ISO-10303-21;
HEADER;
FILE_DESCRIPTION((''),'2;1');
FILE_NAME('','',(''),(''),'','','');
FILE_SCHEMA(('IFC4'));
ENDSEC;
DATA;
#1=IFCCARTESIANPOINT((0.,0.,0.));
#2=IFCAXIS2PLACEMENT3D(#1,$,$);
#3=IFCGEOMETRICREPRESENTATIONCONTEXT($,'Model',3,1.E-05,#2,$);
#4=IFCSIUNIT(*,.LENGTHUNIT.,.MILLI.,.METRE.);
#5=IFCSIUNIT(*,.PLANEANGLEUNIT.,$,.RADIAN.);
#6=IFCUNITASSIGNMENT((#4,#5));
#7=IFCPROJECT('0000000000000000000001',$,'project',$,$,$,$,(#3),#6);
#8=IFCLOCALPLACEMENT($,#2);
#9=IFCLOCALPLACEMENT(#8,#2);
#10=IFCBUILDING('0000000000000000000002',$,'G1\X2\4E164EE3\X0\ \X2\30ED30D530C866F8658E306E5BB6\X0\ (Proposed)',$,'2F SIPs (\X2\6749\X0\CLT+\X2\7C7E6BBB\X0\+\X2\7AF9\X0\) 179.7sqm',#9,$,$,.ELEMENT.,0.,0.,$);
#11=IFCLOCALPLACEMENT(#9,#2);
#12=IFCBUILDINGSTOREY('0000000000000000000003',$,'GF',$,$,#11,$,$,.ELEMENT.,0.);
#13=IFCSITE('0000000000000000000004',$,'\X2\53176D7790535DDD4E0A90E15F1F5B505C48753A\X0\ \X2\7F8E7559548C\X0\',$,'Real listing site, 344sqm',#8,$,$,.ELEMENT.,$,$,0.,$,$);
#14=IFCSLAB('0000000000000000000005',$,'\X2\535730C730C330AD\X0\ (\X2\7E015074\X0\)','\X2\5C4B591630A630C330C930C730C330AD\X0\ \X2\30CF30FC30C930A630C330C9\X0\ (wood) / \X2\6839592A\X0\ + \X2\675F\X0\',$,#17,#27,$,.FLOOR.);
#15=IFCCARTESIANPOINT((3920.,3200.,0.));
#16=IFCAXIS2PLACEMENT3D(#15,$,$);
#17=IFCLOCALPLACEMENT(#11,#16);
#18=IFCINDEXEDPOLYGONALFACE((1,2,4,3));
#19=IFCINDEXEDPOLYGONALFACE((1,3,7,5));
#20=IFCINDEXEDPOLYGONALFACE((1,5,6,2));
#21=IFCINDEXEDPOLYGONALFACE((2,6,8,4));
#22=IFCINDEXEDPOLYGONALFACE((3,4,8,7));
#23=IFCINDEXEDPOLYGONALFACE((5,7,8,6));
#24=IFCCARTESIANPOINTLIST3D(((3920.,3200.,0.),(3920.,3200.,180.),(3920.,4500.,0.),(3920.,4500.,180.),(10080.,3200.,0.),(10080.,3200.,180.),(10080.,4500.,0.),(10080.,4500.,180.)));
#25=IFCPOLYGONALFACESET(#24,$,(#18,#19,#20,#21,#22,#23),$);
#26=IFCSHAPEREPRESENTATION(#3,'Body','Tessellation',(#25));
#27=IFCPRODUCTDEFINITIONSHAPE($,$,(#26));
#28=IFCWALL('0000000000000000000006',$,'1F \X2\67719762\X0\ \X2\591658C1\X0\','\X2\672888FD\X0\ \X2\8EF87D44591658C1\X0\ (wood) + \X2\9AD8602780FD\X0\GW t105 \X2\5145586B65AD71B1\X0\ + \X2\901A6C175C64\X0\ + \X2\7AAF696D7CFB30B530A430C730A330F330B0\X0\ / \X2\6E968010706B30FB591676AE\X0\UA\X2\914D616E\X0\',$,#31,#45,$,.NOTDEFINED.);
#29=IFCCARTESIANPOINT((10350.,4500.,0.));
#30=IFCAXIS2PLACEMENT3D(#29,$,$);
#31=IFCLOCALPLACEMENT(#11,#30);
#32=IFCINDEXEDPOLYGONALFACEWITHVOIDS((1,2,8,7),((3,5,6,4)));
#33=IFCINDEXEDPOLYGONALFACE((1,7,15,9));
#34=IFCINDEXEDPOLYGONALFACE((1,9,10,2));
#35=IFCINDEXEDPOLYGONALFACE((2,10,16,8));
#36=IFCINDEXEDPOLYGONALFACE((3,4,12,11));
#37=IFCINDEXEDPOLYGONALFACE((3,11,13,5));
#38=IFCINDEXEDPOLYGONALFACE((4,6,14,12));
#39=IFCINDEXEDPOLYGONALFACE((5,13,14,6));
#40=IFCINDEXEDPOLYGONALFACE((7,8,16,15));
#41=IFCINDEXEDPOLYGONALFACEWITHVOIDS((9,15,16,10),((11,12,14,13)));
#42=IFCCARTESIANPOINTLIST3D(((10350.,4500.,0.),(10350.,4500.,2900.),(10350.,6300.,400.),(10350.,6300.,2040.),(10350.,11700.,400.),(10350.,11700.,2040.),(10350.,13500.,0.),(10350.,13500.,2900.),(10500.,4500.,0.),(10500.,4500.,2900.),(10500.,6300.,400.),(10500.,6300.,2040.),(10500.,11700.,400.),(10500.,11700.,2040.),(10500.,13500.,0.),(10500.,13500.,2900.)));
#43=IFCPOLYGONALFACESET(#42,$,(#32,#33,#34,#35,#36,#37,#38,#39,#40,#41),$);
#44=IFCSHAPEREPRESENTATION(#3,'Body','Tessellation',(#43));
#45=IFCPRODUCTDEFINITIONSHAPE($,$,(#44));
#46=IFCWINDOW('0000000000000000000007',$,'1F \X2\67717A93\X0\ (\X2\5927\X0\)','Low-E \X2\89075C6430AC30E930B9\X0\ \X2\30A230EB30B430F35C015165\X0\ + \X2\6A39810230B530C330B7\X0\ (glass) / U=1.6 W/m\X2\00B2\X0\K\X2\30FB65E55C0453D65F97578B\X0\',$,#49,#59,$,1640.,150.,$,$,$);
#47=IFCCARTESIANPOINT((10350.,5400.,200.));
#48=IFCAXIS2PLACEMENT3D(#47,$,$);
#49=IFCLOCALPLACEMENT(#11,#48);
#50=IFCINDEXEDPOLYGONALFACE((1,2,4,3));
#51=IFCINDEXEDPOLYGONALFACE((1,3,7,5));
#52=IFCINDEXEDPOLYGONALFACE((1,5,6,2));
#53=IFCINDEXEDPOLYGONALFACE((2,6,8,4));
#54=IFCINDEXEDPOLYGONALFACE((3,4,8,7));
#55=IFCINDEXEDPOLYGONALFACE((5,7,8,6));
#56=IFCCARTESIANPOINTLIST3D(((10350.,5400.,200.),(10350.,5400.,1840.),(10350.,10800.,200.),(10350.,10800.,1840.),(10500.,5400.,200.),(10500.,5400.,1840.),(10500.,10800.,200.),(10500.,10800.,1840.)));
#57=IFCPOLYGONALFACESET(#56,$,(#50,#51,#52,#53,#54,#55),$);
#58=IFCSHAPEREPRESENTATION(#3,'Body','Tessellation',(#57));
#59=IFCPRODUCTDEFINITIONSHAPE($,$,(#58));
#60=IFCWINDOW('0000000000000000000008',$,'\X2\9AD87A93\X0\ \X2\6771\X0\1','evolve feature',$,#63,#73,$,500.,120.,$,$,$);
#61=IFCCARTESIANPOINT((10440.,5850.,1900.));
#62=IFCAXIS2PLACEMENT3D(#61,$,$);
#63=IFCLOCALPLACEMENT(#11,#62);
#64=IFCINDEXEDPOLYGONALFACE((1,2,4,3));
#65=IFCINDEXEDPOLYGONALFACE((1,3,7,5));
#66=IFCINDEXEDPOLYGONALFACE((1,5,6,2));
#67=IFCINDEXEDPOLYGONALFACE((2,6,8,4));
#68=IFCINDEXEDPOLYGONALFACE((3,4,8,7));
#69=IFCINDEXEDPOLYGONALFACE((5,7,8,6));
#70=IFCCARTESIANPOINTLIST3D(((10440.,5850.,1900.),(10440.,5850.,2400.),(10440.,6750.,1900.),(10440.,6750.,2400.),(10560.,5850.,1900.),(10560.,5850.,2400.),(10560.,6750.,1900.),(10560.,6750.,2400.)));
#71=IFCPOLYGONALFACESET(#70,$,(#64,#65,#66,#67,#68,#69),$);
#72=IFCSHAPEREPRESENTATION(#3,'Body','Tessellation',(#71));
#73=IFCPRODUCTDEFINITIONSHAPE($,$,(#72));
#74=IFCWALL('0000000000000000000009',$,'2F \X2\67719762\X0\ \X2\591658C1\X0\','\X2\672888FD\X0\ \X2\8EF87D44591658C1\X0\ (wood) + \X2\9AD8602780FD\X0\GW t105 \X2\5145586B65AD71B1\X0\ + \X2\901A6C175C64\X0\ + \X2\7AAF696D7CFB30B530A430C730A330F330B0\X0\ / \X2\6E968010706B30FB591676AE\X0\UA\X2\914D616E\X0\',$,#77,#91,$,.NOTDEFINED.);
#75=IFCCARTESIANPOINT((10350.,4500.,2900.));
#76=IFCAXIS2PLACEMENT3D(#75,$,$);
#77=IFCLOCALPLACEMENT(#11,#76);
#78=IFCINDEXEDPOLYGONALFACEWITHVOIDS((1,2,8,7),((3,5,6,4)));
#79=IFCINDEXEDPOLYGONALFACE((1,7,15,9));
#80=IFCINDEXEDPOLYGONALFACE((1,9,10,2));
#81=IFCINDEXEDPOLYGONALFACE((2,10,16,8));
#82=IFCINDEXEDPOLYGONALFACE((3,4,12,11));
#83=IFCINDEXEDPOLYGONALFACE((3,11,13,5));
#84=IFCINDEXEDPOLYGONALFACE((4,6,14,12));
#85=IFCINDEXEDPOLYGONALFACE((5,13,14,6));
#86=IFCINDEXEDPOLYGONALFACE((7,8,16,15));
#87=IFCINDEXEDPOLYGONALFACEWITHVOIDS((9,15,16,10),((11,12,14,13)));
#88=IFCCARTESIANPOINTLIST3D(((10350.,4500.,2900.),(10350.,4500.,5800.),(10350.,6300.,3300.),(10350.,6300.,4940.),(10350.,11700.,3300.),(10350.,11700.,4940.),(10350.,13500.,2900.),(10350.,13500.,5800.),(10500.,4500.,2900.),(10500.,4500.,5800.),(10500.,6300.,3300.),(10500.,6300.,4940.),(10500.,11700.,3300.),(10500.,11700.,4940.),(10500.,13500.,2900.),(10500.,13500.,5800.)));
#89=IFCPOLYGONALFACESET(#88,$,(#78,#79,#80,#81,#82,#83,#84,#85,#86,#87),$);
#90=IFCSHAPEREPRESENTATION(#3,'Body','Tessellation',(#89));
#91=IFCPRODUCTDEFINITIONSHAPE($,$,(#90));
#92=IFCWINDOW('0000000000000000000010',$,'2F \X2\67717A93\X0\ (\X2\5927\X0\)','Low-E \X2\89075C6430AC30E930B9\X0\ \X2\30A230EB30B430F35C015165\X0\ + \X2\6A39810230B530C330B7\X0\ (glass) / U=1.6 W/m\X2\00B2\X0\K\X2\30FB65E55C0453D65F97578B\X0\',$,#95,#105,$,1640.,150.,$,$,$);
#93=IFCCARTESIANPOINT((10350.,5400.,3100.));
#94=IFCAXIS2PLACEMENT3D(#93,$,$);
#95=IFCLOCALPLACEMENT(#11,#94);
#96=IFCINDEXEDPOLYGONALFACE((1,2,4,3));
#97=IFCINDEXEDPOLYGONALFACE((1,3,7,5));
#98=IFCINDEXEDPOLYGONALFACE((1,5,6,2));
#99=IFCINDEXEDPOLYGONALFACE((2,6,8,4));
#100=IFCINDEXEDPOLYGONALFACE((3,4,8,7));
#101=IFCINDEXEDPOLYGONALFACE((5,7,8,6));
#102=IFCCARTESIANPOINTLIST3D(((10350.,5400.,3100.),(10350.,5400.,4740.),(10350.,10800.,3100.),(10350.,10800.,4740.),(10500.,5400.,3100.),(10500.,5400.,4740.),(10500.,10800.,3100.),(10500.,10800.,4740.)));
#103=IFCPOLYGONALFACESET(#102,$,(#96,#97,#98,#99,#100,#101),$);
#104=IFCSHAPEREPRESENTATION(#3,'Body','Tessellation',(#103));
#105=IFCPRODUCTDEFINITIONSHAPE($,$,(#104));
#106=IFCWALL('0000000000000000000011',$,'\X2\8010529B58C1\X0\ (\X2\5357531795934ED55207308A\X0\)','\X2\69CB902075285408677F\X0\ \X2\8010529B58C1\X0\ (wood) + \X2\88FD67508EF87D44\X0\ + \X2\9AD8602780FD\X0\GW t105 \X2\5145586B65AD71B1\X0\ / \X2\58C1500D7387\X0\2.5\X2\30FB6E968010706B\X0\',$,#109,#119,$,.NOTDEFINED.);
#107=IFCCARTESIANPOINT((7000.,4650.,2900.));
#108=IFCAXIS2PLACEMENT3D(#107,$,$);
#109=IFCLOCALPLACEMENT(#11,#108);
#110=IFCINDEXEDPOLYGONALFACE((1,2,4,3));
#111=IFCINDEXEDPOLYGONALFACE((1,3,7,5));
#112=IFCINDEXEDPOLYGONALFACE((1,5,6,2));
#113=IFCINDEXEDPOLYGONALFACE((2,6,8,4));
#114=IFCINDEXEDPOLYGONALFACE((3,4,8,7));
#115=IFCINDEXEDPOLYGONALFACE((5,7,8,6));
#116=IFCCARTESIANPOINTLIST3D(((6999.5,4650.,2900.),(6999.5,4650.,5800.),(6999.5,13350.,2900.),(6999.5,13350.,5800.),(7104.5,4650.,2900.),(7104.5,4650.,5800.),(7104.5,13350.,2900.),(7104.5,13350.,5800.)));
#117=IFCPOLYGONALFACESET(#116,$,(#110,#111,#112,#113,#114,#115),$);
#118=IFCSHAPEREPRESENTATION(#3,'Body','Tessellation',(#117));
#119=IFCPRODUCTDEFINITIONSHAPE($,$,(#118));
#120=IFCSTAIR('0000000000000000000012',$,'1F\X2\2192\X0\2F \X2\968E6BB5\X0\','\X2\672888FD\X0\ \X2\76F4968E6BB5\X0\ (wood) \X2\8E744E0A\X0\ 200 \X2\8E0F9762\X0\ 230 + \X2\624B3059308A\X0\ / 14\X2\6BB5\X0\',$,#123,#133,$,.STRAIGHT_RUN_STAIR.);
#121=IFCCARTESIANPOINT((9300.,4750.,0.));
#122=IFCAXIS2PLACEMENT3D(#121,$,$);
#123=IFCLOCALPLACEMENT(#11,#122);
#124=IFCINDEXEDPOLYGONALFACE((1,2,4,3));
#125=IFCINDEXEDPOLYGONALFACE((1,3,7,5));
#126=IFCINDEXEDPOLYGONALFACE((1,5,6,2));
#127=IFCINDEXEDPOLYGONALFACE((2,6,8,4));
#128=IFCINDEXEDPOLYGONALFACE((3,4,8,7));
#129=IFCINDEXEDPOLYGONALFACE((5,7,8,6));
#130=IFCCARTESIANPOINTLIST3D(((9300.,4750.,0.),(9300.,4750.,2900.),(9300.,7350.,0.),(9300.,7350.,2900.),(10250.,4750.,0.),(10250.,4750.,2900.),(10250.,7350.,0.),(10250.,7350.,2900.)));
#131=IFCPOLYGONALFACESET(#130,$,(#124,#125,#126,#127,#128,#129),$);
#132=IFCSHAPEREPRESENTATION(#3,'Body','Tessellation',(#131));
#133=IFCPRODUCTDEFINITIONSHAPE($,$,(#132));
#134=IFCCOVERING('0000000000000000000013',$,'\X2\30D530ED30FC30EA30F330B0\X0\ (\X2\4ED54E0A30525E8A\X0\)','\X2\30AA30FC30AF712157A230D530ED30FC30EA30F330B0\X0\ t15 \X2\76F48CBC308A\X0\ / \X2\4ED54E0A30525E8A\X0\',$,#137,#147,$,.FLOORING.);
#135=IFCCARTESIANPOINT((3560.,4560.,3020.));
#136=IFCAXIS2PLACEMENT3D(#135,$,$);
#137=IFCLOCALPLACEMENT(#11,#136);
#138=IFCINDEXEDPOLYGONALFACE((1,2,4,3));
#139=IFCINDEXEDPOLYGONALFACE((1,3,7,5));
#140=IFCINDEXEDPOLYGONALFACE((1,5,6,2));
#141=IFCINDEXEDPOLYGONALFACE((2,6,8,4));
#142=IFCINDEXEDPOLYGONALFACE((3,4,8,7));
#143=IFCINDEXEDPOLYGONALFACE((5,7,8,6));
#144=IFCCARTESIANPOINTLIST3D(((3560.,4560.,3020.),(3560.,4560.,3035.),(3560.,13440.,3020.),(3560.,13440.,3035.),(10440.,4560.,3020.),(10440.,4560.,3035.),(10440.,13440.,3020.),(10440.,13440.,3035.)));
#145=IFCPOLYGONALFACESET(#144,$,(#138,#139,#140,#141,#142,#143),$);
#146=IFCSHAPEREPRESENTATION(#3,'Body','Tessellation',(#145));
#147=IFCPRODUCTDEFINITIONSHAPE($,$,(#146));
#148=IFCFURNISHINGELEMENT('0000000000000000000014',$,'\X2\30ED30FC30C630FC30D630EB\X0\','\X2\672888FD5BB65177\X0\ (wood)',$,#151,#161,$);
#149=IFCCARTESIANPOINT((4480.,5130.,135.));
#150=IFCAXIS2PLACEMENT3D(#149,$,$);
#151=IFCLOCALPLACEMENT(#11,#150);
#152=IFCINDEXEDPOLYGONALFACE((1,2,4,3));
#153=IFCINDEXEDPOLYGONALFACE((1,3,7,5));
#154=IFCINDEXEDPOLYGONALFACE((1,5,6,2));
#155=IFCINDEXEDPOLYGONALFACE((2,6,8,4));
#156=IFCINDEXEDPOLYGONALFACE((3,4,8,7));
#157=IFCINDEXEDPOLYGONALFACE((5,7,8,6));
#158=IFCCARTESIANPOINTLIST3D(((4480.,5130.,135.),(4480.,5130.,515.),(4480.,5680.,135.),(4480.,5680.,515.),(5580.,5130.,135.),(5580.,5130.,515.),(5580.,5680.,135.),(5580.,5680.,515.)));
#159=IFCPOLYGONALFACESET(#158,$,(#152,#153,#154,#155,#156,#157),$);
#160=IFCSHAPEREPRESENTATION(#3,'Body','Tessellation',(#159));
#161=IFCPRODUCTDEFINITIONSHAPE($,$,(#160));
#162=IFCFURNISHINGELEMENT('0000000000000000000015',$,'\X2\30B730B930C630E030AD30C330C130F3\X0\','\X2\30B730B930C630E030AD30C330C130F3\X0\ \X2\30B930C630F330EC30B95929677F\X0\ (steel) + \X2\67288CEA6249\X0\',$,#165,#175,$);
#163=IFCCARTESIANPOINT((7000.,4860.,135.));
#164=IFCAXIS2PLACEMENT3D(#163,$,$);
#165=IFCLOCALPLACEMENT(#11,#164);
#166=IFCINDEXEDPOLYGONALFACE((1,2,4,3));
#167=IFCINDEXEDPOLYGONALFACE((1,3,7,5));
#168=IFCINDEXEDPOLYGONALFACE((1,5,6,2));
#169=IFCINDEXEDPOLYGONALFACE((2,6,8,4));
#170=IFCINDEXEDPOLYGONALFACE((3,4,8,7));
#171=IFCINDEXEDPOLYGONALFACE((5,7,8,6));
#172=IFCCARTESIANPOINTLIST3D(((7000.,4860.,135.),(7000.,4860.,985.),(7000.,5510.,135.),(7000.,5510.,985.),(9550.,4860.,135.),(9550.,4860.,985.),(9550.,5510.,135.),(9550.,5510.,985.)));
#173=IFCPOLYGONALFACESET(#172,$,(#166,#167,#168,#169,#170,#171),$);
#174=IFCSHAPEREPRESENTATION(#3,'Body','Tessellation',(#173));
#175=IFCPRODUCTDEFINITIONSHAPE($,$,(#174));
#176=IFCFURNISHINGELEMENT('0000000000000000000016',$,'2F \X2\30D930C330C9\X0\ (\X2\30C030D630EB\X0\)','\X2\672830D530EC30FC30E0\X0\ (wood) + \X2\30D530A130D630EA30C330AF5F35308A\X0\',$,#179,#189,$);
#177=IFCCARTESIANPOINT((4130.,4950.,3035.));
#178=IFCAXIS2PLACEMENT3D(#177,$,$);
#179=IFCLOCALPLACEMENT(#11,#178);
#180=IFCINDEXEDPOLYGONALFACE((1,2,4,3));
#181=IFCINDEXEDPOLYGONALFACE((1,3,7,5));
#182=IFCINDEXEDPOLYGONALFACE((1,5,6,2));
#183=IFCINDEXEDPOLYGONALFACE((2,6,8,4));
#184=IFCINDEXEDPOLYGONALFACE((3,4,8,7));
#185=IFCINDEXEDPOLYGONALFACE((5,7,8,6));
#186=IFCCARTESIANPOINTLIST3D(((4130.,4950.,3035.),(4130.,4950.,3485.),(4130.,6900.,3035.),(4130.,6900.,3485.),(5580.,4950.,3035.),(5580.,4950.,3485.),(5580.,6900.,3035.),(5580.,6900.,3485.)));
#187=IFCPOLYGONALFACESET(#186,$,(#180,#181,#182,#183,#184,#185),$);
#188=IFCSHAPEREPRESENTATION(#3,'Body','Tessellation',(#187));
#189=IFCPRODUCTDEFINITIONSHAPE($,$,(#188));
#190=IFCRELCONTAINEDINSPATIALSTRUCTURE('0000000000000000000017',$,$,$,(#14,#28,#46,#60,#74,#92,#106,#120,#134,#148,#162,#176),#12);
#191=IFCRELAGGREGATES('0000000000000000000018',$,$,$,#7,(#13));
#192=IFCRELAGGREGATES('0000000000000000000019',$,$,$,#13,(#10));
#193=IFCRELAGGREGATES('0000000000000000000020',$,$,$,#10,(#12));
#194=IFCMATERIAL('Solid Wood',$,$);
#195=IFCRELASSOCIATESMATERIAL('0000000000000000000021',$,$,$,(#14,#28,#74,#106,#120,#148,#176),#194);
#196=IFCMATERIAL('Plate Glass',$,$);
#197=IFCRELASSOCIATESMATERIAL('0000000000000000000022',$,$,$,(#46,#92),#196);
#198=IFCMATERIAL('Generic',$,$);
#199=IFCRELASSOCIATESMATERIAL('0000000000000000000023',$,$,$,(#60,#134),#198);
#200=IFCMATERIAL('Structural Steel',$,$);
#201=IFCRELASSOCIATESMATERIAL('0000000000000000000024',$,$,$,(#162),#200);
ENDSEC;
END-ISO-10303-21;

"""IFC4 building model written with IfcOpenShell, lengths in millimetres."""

from ifc_helpers import new_model, si_unit, frame, frame_2d, origin, place, context, project, spatial, rectangle, extrude, material, element, fill, save


model = new_model("IFC4")

# Units and contexts
model_context = context("Model", 3, precision=1e-05, world=origin())
ifc_project = project(units=[si_unit("LENGTHUNIT", "METRE", prefix="MILLI"), si_unit("PLANEANGLEUNIT", "RADIAN")], contexts=[model_context])

# Site, building, storey
site_placement = place(None, origin())
site = spatial("IfcSite", under=ifc_project, at=site_placement, Name="北海道川上郡弟子屈町 美留和", ObjectType="Real listing site, 344sqm", CompositionType="ELEMENT", RefElevation=0.0)
building_placement = place(site_placement, origin())
building = spatial("IfcBuilding", under=site, at=building_placement, Name="G1世代 ロフト書斎の家 (Proposed)", ObjectType="2F SIPs (杉CLT+籾殻+竹) 179.7sqm", CompositionType="ELEMENT", ElevationOfRefHeight=0.0, ElevationOfTerrain=0.0)
storey_placement = place(building_placement, origin())
storey = spatial("IfcBuildingStorey", under=building, at=storey_placement, Name="GF", CompositionType="ELEMENT", Elevation=0.0)

# Slab
ifc_material_1 = material(Name="Solid Wood")
slab_placement = place(storey_placement, frame((3920.0, 3200.0, 0.0)))
element("IfcSlab", 1, at=slab_placement, inside=storey, material=ifc_material_1, Name="南デッキ (縁側)", Description="屋外ウッドデッキ ハードウッド (wood) / 根太 + 束", PredefinedType="FLOOR", context=model_context, shape_type="SweptSolid", body=[
    extrude(rectangle(XDim=6160.0, YDim=1300.0, at=frame_2d((3080.0, 650.0))), frame((3920.0, 3200.0, 0.0)), (0.0, 0.0, 1.0), 180.0),
])

# Wall, openings, windows
wall_1_placement = place(storey_placement, frame((10350.0, 4500.0, 0.0)))
wall_1 = element("IfcWall", 2, at=wall_1_placement, inside=storey, material=ifc_material_1, Name="1F 東面 外壁", Description="木製 軸組外壁 (wood) + 高性能GW t105 充填断熱 + 通気層 + 窯業系サイディング / 準耐火・外皮UA配慮", PredefinedType="NOTDEFINED", context=model_context, shape_type="SweptSolid", body=[
    extrude(rectangle(XDim=150.0, YDim=9000.0, at=frame_2d((75.0, 4500.0))), frame((10350.0, 4500.0, 0.0)), (0.0, 0.0, 1.0), 2900.0),
])
opening_1_placement = place(storey_placement, frame((10350.0, 5400.0, 200.0)))
opening_1 = element("IfcOpeningElement", 3, at=opening_1_placement, cuts=wall_1, PredefinedType="NOTDEFINED", context=model_context, shape_type="SweptSolid", body=[
    extrude(rectangle(XDim=150.0, YDim=5400.0, at=frame_2d((75.0, 2700.0))), frame((10350.0, 5400.0, 200.0)), (0.0, 0.0, 1.0), 1640.0),
])
opening_2_placement = place(storey_placement, frame((10440.0, 5850.0, 1900.0)))
opening_2 = element("IfcOpeningElement", 4, at=opening_2_placement, cuts=wall_1, PredefinedType="NOTDEFINED", context=model_context, shape_type="SweptSolid", body=[
    extrude(rectangle(XDim=120.0, YDim=900.0, at=frame_2d((60.0, 450.0))), frame((10440.0, 5850.0, 1900.0)), (0.0, 0.0, 1.0), 500.0),
])
ifc_material_2 = material(Name="Plate Glass")
window_1_placement = place(storey_placement, frame((10350.0, 5400.0, 200.0)))
window_1 = element("IfcWindow", 5, at=window_1_placement, inside=storey, material=ifc_material_2, Name="1F 東窓 (大)", Description="Low-E 複層ガラス アルゴン封入 + 樹脂サッシ (glass) / U=1.6 W/m²K・日射取得型", OverallHeight=1640.0, OverallWidth=150.0, context=model_context, shape_type="SweptSolid", body=[
    extrude(rectangle(XDim=150.0, YDim=5400.0, at=frame_2d((75.0, 2700.0))), frame((10350.0, 5400.0, 200.0)), (0.0, 0.0, 1.0), 1640.0),
])
fill(opening_1, window_1)
ifc_material_3 = material(Name="Generic")
window_2_placement = place(storey_placement, frame((10440.0, 5850.0, 1900.0)))
window_2 = element("IfcWindow", 6, at=window_2_placement, inside=storey, material=ifc_material_3, Name="高窓 東1", Description="evolve feature", OverallHeight=500.0, OverallWidth=120.0, context=model_context, shape_type="SweptSolid", body=[
    extrude(rectangle(XDim=120.0, YDim=900.0, at=frame_2d((60.0, 450.0))), frame((10440.0, 5850.0, 1900.0)), (0.0, 0.0, 1.0), 500.0),
])
fill(opening_2, window_2)

# Wall, opening, window
wall_2_placement = place(storey_placement, frame((10350.0, 4500.0, 2900.0)))
wall_2 = element("IfcWall", 7, at=wall_2_placement, inside=storey, material=ifc_material_1, Name="2F 東面 外壁", Description="木製 軸組外壁 (wood) + 高性能GW t105 充填断熱 + 通気層 + 窯業系サイディング / 準耐火・外皮UA配慮", PredefinedType="NOTDEFINED", context=model_context, shape_type="SweptSolid", body=[
    extrude(rectangle(XDim=150.0, YDim=9000.0, at=frame_2d((75.0, 4500.0))), frame((10350.0, 4500.0, 2900.0)), (0.0, 0.0, 1.0), 2900.0),
])
opening_3_placement = place(storey_placement, frame((10350.0, 5400.0, 3100.0)))
opening_3 = element("IfcOpeningElement", 8, at=opening_3_placement, cuts=wall_2, PredefinedType="NOTDEFINED", context=model_context, shape_type="SweptSolid", body=[
    extrude(rectangle(XDim=150.0, YDim=5400.0, at=frame_2d((75.0, 2700.0))), frame((10350.0, 5400.0, 3100.0)), (0.0, 0.0, 1.0), 1640.0),
])
window_3_placement = place(storey_placement, frame((10350.0, 5400.0, 3100.0)))
window_3 = element("IfcWindow", 9, at=window_3_placement, inside=storey, material=ifc_material_2, Name="2F 東窓 (大)", Description="Low-E 複層ガラス アルゴン封入 + 樹脂サッシ (glass) / U=1.6 W/m²K・日射取得型", OverallHeight=1640.0, OverallWidth=150.0, context=model_context, shape_type="SweptSolid", body=[
    extrude(rectangle(XDim=150.0, YDim=5400.0, at=frame_2d((75.0, 2700.0))), frame((10350.0, 5400.0, 3100.0)), (0.0, 0.0, 1.0), 1640.0),
])
fill(opening_3, window_3)

# Wall
wall_3_placement = place(storey_placement, frame((7000.0, 4650.0, 2900.0)))
element("IfcWall", 10, at=wall_3_placement, inside=storey, material=ifc_material_1, Name="耐力壁 (南北間仕切り)", Description="構造用合板 耐力壁 (wood) + 製材軸組 + 高性能GW t105 充填断熱 / 壁倍率2.5・準耐火", PredefinedType="NOTDEFINED", context=model_context, shape_type="SweptSolid", body=[
    extrude(rectangle(XDim=105.0, YDim=8700.0, at=frame_2d((52.0, 4350.0))), frame((7000.0, 4650.0, 2900.0)), (0.0, 0.0, 1.0), 2900.0),
])

# Stair
stair_placement = place(storey_placement, frame((9300.0, 4750.0, 0.0)))
element("IfcStair", 11, at=stair_placement, inside=storey, material=ifc_material_1, Name="1F→2F 階段", Description="木製 直階段 (wood) 蹴上 200 踏面 230 + 手すり / 14段", PredefinedType="STRAIGHT_RUN_STAIR", context=model_context, shape_type="SweptSolid", body=[
    extrude(rectangle(XDim=950.0, YDim=2600.0, at=frame_2d((475.0, 1300.0))), frame((9300.0, 4750.0, 0.0)), (0.0, 0.0, 1.0), 2900.0),
])

# Covering
covering_placement = place(storey_placement, frame((3560.0, 4560.0, 3020.0)))
element("IfcCovering", 12, at=covering_placement, inside=storey, material=ifc_material_3, Name="フローリング (仕上げ床)", Description="オーク無垢フローリング t15 直貼り / 仕上げ床", PredefinedType="FLOORING", context=model_context, shape_type="SweptSolid", body=[
    extrude(rectangle(XDim=6880.0, YDim=8880.0, at=frame_2d((3440.0, 4440.0))), frame((3560.0, 4560.0, 3020.0)), (0.0, 0.0, 1.0), 15.0),
])

# Furnishing elements
furnishing_1_placement = place(storey_placement, frame((4480.0, 5130.0, 135.0)))
element("IfcFurnishingElement", 13, at=furnishing_1_placement, inside=storey, material=ifc_material_1, Name="ローテーブル", Description="木製家具 (wood)", context=model_context, shape_type="SweptSolid", body=[
    extrude(rectangle(XDim=1100.0, YDim=550.0, at=frame_2d((550.0, 275.0))), frame((4480.0, 5130.0, 135.0)), (0.0, 0.0, 1.0), 380.0),
])
ifc_material_4 = material(Name="Structural Steel")
furnishing_2_placement = place(storey_placement, frame((7000.0, 4860.0, 135.0)))
element("IfcFurnishingElement", 14, at=furnishing_2_placement, inside=storey, material=ifc_material_4, Name="システムキッチン", Description="システムキッチン ステンレス天板 (steel) + 木質扉", context=model_context, shape_type="SweptSolid", body=[
    extrude(rectangle(XDim=2550.0, YDim=650.0, at=frame_2d((1275.0, 325.0))), frame((7000.0, 4860.0, 135.0)), (0.0, 0.0, 1.0), 850.0),
])
furnishing_3_placement = place(storey_placement, frame((4130.0, 4950.0, 3035.0)))
element("IfcFurnishingElement", 15, at=furnishing_3_placement, inside=storey, material=ifc_material_1, Name="2F ベッド (ダブル)", Description="木フレーム (wood) + ファブリック張り", context=model_context, shape_type="SweptSolid", body=[
    extrude(rectangle(XDim=1450.0, YDim=1950.0, at=frame_2d((725.0, 975.0))), frame((4130.0, 4950.0, 3035.0)), (0.0, 0.0, 1.0), 450.0),
])

save(model, "model.ifc")
